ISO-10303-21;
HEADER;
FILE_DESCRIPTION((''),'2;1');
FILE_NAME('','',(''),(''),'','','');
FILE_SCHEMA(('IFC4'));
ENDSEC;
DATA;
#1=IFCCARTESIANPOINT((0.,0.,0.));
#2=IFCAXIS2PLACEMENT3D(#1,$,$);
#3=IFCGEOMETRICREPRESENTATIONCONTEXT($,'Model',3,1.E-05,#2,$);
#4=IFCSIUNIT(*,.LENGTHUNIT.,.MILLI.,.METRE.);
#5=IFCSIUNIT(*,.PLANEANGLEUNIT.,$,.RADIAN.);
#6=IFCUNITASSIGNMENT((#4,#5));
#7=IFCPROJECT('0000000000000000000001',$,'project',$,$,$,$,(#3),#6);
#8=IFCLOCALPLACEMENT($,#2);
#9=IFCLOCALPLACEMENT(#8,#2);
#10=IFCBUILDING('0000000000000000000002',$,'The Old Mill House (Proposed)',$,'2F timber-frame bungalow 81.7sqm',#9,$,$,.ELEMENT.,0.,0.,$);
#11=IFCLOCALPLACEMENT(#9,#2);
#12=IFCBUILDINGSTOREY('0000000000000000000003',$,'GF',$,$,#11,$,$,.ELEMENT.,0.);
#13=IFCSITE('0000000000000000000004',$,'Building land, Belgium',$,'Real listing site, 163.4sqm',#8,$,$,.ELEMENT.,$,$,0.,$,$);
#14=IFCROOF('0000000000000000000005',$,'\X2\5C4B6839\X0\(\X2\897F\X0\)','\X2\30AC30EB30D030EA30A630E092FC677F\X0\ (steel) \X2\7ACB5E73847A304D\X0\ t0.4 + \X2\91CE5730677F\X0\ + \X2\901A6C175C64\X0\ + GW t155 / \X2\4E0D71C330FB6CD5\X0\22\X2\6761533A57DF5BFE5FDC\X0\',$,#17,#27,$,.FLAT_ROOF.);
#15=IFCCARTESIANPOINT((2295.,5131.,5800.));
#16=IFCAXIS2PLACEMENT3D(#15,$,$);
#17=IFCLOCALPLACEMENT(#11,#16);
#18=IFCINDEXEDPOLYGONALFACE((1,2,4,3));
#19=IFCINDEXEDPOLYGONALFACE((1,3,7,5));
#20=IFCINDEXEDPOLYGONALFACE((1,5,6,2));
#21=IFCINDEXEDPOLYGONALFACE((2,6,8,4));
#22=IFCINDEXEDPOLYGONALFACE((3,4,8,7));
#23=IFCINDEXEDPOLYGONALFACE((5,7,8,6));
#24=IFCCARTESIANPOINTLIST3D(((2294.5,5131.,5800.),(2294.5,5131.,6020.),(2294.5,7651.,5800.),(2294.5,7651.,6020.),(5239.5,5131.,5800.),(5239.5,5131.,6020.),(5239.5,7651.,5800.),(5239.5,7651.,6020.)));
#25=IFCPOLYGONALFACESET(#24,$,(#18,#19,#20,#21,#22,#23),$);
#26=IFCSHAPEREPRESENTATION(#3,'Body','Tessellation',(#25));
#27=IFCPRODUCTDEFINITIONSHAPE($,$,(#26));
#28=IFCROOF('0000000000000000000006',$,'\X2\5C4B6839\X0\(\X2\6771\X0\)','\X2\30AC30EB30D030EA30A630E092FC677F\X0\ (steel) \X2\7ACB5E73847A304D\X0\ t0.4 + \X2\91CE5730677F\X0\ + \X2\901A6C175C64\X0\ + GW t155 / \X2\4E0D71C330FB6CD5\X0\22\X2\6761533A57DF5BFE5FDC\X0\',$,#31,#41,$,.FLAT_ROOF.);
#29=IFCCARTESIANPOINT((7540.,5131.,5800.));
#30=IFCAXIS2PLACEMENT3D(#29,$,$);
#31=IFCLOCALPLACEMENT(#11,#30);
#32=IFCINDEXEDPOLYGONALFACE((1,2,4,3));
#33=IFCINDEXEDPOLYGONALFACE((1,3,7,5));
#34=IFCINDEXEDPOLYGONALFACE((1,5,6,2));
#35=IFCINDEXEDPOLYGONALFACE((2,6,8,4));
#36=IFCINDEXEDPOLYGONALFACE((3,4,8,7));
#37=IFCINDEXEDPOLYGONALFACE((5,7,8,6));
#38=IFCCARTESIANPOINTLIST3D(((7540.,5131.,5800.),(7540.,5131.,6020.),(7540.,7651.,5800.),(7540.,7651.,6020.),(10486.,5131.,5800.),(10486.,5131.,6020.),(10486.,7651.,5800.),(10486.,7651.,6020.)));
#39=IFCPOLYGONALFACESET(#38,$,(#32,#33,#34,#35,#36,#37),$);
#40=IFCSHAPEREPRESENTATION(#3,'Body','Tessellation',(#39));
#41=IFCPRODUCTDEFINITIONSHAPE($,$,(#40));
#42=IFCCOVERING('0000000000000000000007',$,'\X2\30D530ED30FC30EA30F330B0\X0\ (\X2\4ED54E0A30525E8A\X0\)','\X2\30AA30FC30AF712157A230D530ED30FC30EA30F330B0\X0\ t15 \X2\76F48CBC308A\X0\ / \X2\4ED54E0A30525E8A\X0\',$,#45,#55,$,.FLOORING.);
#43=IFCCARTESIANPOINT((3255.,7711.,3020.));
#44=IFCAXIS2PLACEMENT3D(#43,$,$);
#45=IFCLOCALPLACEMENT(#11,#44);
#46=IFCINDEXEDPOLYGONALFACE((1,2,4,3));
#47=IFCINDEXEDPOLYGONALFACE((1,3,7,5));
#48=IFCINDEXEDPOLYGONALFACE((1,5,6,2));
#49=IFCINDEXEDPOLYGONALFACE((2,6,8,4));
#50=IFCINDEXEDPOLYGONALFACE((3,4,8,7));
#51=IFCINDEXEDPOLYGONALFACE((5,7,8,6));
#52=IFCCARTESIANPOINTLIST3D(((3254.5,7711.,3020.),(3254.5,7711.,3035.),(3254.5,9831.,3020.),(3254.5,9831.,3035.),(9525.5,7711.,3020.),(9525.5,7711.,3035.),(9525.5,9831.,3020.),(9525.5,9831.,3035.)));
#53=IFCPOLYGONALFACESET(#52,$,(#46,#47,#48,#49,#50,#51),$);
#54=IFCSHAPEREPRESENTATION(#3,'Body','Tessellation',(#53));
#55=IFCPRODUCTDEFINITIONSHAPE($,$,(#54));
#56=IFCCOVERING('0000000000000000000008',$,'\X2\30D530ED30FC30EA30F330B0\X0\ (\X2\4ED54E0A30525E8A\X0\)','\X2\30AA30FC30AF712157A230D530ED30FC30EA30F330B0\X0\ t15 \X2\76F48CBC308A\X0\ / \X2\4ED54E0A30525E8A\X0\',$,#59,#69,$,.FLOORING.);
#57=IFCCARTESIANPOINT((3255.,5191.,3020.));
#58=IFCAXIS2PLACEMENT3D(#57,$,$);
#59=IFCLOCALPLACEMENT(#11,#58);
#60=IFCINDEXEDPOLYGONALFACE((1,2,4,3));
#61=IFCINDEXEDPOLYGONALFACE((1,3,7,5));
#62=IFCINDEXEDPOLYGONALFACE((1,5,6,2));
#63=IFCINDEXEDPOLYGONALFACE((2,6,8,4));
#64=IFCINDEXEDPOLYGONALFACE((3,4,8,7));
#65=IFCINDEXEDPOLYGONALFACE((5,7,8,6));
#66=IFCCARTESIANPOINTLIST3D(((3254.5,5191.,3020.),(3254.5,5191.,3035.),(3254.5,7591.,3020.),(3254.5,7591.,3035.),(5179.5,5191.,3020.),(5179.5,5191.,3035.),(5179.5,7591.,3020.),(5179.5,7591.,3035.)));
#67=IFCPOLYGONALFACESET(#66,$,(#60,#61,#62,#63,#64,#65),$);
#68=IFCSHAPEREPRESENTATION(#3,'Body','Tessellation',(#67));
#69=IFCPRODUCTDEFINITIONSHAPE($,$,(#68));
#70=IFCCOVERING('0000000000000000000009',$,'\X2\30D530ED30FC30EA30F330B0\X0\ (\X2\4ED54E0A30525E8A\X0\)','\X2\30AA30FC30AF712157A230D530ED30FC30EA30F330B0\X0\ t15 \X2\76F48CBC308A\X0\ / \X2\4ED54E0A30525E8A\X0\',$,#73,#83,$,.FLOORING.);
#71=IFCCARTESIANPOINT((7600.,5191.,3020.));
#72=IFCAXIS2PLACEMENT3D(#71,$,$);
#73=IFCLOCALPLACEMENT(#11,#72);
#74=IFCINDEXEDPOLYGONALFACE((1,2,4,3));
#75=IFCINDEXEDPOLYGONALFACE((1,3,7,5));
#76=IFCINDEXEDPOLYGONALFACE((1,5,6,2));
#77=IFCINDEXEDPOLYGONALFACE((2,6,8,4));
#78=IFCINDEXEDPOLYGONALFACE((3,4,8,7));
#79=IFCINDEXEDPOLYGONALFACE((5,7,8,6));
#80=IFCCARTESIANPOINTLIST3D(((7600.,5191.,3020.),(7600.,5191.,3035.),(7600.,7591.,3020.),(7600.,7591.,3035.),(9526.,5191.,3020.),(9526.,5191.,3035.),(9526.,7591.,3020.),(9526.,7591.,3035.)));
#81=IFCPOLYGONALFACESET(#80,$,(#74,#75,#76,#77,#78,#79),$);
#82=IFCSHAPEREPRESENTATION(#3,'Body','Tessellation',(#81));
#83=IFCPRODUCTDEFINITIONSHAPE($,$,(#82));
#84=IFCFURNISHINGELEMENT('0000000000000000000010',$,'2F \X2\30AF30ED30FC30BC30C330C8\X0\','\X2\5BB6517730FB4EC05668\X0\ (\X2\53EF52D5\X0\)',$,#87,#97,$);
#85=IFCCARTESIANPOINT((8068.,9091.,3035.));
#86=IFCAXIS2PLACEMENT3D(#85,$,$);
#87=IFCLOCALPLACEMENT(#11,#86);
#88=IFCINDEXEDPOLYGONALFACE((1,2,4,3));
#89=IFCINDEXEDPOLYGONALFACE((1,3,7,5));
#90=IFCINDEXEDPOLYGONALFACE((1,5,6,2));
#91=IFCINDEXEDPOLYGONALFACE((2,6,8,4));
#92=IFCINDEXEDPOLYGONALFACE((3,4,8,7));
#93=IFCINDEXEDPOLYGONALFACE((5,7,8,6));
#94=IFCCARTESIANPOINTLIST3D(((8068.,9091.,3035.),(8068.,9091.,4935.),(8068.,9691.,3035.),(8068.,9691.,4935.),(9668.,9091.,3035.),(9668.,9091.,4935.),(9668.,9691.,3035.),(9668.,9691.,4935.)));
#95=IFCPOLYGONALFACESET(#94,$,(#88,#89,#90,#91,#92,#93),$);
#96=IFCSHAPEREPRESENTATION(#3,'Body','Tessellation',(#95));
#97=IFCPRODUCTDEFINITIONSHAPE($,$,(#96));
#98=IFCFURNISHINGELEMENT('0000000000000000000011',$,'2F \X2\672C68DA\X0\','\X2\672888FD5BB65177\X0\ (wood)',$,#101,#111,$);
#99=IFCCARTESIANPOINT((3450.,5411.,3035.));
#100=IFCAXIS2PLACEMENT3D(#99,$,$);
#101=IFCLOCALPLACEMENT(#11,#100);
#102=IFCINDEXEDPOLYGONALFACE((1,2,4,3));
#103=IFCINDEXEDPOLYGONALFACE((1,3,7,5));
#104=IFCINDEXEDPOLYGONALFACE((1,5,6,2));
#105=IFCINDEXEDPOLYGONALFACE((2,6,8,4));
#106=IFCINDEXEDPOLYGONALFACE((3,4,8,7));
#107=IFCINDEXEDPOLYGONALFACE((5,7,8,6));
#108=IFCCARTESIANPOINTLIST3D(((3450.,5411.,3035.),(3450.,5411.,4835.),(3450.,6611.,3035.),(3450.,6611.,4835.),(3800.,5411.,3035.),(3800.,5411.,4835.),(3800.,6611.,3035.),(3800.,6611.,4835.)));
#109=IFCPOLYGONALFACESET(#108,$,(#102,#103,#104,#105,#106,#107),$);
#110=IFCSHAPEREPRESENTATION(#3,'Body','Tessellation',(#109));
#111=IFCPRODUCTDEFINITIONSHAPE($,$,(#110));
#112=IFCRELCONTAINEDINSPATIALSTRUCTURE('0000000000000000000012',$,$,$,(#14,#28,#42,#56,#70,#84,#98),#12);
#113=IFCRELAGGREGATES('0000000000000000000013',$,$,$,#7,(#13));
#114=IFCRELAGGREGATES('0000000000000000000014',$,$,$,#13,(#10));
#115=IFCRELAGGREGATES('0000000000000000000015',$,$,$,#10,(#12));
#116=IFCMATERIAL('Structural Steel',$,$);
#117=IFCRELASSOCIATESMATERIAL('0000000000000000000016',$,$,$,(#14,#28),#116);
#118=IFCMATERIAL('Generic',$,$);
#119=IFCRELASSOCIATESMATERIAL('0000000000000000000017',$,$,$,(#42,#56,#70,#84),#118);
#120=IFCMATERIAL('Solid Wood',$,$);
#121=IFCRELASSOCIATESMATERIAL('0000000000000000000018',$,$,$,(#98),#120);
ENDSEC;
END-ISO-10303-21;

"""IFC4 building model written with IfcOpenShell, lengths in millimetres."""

from ifc_helpers import new_model, si_unit, frame, frame_2d, origin, place, context, project, spatial, rectangle, extrude, material, element, save


model = new_model("IFC4")

# Units and contexts
model_context = context("Model", 3, precision=1e-05, world=origin())
ifc_project = project(units=[si_unit("LENGTHUNIT", "METRE", prefix="MILLI"), si_unit("PLANEANGLEUNIT", "RADIAN")], contexts=[model_context])

# Site, building, storey
site_placement = place(None, origin())
site = spatial("IfcSite", under=ifc_project, at=site_placement, Name="Building land, Belgium", ObjectType="Real listing site, 163.4sqm", CompositionType="ELEMENT", RefElevation=0.0)
building_placement = place(site_placement, origin())
building = spatial("IfcBuilding", under=site, at=building_placement, Name="The Old Mill House (Proposed)", ObjectType="2F timber-frame bungalow 81.7sqm", CompositionType="ELEMENT", ElevationOfRefHeight=0.0, ElevationOfTerrain=0.0)
storey_placement = place(building_placement, origin())
storey = spatial("IfcBuildingStorey", under=building, at=storey_placement, Name="GF", CompositionType="ELEMENT", Elevation=0.0)

# Shared definitions
ifc_material_1 = material(Name="Solid Wood")

# Roofs
ifc_material_2 = material(Name="Structural Steel")
roof_1_placement = place(storey_placement, frame((2295.0, 5131.0, 5800.0)))
element("IfcRoof", 1, at=roof_1_placement, inside=storey, material=ifc_material_2, Name="屋根(西)", Description="ガルバリウム鋼板 (steel) 立平葺き t0.4 + 野地板 + 通気層 + GW t155 / 不燃・法22条区域対応", PredefinedType="FLAT_ROOF", context=model_context, shape_type="SweptSolid", body=[
    extrude(rectangle(XDim=2945.0, YDim=2520.0, at=frame_2d((1472.0, 1260.0))), frame((2295.0, 5131.0, 5800.0)), (0.0, 0.0, 1.0), 220.0),
])
roof_2_placement = place(storey_placement, frame((7540.0, 5131.0, 5800.0)))
element("IfcRoof", 2, at=roof_2_placement, inside=storey, material=ifc_material_2, Name="屋根(東)", Description="ガルバリウム鋼板 (steel) 立平葺き t0.4 + 野地板 + 通気層 + GW t155 / 不燃・法22条区域対応", PredefinedType="FLAT_ROOF", context=model_context, shape_type="SweptSolid", body=[
    extrude(rectangle(XDim=2946.0, YDim=2520.0, at=frame_2d((1473.0, 1260.0))), frame((7540.0, 5131.0, 5800.0)), (0.0, 0.0, 1.0), 220.0),
])

# Coverings
ifc_material_3 = material(Name="Generic")
covering_1_placement = place(storey_placement, frame((3255.0, 7711.0, 3020.0)))
element("IfcCovering", 3, at=covering_1_placement, inside=storey, material=ifc_material_3, Name="フローリング (仕上げ床)", Description="オーク無垢フローリング t15 直貼り / 仕上げ床", PredefinedType="FLOORING", context=model_context, shape_type="SweptSolid", body=[
    extrude(rectangle(XDim=6271.0, YDim=2120.0, at=frame_2d((3135.0, 1060.0))), frame((3255.0, 7711.0, 3020.0)), (0.0, 0.0, 1.0), 15.0),
])
covering_2_placement = place(storey_placement, frame((3255.0, 5191.0, 3020.0)))
element("IfcCovering", 4, at=covering_2_placement, inside=storey, material=ifc_material_3, Name="フローリング (仕上げ床)", Description="オーク無垢フローリング t15 直貼り / 仕上げ床", PredefinedType="FLOORING", context=model_context, shape_type="SweptSolid", body=[
    extrude(rectangle(XDim=1925.0, YDim=2400.0, at=frame_2d((962.0, 1200.0))), frame((3255.0, 5191.0, 3020.0)), (0.0, 0.0, 1.0), 15.0),
])
covering_3_placement = place(storey_placement, frame((7600.0, 5191.0, 3020.0)))
element("IfcCovering", 5, at=covering_3_placement, inside=storey, material=ifc_material_3, Name="フローリング (仕上げ床)", Description="オーク無垢フローリング t15 直貼り / 仕上げ床", PredefinedType="FLOORING", context=model_context, shape_type="SweptSolid", body=[
    extrude(rectangle(XDim=1926.0, YDim=2400.0, at=frame_2d((963.0, 1200.0))), frame((7600.0, 5191.0, 3020.0)), (0.0, 0.0, 1.0), 15.0),
])

# Furnishing elements
furnishing_1_placement = place(storey_placement, frame((8068.0, 9091.0, 3035.0)))
element("IfcFurnishingElement", 6, at=furnishing_1_placement, inside=storey, material=ifc_material_3, Name="2F クローゼット", Description="家具・什器 (可動)", context=model_context, shape_type="SweptSolid", body=[
    extrude(rectangle(XDim=1600.0, YDim=600.0, at=frame_2d((800.0, 300.0))), frame((8068.0, 9091.0, 3035.0)), (0.0, 0.0, 1.0), 1900.0),
])
furnishing_2_placement = place(storey_placement, frame((3450.0, 5411.0, 3035.0)))
element("IfcFurnishingElement", 7, at=furnishing_2_placement, inside=storey, material=ifc_material_1, Name="2F 本棚", Description="木製家具 (wood)", context=model_context, shape_type="SweptSolid", body=[
    extrude(rectangle(XDim=350.0, YDim=1200.0, at=frame_2d((175.0, 600.0))), frame((3450.0, 5411.0, 3035.0)), (0.0, 0.0, 1.0), 1800.0),
])

save(model, "model.ifc")
